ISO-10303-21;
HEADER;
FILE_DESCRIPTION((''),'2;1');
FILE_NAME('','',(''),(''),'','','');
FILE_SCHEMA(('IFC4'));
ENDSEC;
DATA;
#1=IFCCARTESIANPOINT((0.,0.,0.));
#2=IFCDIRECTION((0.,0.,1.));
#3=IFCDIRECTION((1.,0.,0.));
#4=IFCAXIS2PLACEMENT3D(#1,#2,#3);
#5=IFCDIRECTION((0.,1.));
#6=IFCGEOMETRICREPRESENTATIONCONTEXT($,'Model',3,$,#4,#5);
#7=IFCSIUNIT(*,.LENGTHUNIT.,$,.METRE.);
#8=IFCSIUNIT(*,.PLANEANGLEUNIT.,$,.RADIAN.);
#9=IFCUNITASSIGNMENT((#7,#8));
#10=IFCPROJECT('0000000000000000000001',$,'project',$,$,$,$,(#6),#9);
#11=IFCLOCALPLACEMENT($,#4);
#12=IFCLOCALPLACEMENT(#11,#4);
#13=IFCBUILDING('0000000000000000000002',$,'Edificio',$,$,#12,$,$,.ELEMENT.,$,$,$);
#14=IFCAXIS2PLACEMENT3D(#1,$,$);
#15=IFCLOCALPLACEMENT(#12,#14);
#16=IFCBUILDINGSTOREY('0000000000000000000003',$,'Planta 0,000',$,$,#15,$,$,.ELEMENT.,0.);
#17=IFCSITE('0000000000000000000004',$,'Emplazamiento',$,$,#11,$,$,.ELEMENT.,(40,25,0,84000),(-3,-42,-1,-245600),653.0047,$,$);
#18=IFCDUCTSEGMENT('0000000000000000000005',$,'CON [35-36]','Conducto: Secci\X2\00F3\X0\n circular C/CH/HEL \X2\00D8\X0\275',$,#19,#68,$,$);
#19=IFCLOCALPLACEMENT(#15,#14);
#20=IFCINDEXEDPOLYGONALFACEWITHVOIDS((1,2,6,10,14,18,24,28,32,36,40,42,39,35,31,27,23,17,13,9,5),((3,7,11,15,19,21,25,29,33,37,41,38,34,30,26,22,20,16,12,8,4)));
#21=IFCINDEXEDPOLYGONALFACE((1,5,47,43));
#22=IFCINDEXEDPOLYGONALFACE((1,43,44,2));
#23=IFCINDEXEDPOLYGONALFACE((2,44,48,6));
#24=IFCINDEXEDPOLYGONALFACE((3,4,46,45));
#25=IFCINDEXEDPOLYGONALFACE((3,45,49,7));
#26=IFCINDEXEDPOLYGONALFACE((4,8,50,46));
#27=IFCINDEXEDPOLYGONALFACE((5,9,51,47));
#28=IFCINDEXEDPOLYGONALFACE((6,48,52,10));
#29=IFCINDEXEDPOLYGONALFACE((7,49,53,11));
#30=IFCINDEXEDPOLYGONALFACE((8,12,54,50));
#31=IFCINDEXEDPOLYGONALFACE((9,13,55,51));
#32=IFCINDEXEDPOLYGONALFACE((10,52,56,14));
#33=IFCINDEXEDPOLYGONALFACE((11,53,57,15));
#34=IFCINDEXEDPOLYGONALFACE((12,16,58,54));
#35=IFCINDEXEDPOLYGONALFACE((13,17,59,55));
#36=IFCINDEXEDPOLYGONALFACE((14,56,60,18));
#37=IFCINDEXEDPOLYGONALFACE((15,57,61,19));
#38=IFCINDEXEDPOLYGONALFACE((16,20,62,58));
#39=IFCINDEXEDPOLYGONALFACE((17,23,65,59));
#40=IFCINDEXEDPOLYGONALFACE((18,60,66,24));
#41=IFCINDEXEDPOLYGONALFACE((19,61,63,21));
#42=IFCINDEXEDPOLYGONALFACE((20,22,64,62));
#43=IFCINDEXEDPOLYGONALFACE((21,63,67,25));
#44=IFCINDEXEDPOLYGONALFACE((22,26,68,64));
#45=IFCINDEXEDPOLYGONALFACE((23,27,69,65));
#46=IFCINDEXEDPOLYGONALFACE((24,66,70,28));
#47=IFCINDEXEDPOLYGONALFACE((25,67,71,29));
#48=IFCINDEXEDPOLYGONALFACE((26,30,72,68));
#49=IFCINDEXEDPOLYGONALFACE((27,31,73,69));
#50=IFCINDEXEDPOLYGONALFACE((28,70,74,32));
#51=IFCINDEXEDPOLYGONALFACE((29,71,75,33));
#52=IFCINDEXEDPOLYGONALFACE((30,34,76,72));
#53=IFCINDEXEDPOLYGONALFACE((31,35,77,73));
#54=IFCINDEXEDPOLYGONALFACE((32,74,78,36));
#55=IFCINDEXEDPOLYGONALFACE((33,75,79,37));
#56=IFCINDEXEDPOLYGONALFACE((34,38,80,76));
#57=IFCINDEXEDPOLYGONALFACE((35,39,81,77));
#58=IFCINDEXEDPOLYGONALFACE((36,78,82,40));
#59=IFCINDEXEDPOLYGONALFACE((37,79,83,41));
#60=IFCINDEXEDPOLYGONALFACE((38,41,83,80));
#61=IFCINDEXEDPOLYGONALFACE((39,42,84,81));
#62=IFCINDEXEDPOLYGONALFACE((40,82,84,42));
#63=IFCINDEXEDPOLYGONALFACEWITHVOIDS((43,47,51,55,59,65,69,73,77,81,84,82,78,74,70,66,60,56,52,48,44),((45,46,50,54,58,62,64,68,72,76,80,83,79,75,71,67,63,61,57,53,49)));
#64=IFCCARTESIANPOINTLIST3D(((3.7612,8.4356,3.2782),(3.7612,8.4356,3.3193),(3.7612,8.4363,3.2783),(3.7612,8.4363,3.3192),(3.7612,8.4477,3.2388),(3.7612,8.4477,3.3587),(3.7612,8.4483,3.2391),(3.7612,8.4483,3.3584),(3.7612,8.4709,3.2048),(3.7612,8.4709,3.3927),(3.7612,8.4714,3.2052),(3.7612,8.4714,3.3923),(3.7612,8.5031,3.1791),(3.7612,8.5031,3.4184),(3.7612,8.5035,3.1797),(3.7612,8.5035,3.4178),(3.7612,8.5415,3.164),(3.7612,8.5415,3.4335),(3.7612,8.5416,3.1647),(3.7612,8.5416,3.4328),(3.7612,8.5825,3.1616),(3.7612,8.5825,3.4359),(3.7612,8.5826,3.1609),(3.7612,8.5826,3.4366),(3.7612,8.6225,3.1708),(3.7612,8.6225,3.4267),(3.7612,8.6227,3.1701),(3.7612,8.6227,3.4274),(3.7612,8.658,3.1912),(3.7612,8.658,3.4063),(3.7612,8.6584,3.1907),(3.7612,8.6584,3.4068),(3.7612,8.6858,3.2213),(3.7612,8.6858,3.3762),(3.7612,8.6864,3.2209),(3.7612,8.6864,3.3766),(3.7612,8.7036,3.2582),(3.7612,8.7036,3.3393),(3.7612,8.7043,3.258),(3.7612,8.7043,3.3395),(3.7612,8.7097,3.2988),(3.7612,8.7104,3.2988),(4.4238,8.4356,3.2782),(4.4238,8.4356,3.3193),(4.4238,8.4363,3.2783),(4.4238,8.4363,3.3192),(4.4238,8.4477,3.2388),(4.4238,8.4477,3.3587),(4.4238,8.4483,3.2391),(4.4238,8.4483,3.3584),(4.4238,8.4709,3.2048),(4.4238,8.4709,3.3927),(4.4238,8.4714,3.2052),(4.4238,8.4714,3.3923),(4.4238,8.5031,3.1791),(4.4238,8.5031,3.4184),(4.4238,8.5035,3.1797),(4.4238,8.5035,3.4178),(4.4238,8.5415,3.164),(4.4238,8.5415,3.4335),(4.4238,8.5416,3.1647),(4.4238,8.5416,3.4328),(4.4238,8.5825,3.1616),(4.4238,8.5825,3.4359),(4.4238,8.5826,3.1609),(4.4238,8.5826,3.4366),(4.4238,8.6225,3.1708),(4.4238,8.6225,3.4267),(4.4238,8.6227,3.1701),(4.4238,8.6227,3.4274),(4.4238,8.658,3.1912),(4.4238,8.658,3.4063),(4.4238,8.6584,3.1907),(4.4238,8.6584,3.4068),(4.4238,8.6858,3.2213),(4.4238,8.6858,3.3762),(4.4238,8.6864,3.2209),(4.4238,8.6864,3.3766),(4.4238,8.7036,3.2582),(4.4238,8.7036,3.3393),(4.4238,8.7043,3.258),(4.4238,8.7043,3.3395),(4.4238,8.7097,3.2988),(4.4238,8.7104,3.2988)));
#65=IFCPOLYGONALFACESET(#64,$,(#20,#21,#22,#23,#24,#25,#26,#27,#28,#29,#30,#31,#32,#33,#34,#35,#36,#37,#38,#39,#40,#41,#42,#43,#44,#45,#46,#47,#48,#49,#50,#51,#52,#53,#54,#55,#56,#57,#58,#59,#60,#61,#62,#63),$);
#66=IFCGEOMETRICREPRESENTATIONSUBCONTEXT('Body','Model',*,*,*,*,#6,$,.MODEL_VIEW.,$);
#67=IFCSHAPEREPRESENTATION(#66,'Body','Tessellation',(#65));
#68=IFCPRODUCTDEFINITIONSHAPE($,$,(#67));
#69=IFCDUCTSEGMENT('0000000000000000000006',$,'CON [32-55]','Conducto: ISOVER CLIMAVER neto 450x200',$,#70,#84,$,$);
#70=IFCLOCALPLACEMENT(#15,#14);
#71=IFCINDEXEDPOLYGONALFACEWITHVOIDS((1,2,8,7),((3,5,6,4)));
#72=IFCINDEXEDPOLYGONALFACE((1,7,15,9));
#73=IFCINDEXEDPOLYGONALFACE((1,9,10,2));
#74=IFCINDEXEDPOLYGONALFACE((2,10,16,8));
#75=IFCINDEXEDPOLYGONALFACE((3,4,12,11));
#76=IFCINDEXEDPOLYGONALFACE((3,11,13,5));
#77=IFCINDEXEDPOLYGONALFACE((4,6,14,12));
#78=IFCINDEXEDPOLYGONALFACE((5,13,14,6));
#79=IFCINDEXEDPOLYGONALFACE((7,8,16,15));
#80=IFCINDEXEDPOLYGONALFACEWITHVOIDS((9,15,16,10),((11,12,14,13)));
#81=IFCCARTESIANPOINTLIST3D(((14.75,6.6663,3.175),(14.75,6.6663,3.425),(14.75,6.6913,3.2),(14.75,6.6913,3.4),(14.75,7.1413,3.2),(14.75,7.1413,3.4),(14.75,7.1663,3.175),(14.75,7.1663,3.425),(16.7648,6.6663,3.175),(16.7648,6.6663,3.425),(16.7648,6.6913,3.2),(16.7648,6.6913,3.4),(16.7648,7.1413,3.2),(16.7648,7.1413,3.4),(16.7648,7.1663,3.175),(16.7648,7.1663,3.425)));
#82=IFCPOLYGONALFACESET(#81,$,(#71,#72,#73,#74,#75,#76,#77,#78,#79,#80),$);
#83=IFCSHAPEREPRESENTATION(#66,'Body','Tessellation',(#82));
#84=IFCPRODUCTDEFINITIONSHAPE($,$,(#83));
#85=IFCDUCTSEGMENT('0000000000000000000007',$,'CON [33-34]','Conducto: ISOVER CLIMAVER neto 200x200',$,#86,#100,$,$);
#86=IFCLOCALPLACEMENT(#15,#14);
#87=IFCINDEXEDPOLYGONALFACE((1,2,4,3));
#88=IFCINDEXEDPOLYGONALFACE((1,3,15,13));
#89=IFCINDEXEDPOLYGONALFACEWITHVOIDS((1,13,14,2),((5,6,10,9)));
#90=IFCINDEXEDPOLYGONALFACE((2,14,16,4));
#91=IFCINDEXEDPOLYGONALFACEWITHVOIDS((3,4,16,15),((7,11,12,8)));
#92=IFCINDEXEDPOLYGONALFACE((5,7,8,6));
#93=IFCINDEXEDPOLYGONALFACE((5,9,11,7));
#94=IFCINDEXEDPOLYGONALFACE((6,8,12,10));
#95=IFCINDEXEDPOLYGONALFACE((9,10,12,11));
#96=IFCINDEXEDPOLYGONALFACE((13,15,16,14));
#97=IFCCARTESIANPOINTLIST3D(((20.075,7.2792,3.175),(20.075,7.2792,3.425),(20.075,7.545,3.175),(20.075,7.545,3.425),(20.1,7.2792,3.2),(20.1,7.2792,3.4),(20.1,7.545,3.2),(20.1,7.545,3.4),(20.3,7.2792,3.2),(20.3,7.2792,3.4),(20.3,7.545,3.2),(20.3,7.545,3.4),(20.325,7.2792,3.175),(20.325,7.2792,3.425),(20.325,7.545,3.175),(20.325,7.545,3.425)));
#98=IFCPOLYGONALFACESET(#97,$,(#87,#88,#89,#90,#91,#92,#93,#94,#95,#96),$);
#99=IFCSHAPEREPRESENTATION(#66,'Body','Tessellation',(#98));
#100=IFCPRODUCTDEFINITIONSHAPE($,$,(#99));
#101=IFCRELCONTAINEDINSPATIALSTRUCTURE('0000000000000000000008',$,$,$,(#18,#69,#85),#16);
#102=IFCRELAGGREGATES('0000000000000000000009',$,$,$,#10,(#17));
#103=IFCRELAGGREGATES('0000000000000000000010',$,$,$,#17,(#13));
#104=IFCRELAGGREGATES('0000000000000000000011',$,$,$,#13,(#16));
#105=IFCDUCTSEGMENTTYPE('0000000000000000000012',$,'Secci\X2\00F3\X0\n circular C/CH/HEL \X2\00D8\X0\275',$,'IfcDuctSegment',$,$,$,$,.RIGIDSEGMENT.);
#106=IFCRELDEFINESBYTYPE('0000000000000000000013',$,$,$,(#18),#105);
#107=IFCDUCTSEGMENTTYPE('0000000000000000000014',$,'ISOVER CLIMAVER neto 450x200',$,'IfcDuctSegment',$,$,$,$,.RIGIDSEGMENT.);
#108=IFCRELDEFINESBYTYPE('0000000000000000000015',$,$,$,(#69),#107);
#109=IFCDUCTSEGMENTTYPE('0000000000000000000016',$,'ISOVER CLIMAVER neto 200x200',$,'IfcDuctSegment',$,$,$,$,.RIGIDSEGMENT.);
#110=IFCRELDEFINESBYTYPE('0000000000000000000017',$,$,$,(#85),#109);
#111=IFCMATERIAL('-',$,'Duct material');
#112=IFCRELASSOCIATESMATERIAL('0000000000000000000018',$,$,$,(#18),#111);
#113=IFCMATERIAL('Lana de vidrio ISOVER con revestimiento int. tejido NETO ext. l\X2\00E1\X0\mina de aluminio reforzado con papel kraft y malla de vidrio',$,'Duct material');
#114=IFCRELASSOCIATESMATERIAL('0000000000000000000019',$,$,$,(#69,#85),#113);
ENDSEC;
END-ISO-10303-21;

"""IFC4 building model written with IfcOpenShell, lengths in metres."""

from ifc_helpers import new_model, si_unit, direction, frame, origin, origin_with_axes, origin_2d_with_axis, place, context, subcontext, project, spatial, hollow_rectangle, hollow_circle, extrude, material, type_object, element, save


model = new_model("IFC4")

# Units and contexts
model_context = context("Model", 3, world=origin_with_axes(), true_north=direction((0.0, 1.0)))
body_context = subcontext(model_context, "Body", "Model", "MODEL_VIEW")
ifc_project = project(units=[si_unit("LENGTHUNIT", "METRE"), si_unit("PLANEANGLEUNIT", "RADIAN")], contexts=[model_context])

# Site, building, storey
site_placement = place(None, origin_with_axes())
site = spatial("IfcSite", under=ifc_project, at=site_placement, Name="Emplazamiento", CompositionType="ELEMENT", RefLatitude=(40, 25, 0, 84000), RefLongitude=(-3, -42, -1, -245600), RefElevation=653.0047)
building_placement = place(site_placement, origin_with_axes())
building = spatial("IfcBuilding", under=site, at=building_placement, Name="Edificio", CompositionType="ELEMENT")
storey_placement = place(building_placement, origin())
storey = spatial("IfcBuildingStorey", under=building, at=storey_placement, Name="Planta 0,000", CompositionType="ELEMENT", Elevation=0.0)

# Shared definitions
ifc_material_1 = material(Name="Lana de vidrio ISOVER con revestimiento int. tejido NETO ext. lámina de aluminio reforzado con papel kraft y malla de vidrio", Category="Duct material")
ifc_material_2 = material(Name="-", Category="Duct material")

# Duct segments
duct_segment_type_1 = type_object("IfcDuctSegmentType", Name="Sección circular C/CH/HEL Ø275", ApplicableOccurrence="IfcDuctSegment", PredefinedType="RIGIDSEGMENT")
duct_segment_1_placement = place(storey_placement, origin_with_axes())
element("IfcDuctSegment", 1, at=duct_segment_1_placement, inside=storey, type_object=duct_segment_type_1, material=ifc_material_2, Name="CON [35-36]", Description="Conducto: Sección circular C/CH/HEL Ø275", context=body_context, shape_type="SweptSolid", body=[
    extrude(hollow_circle(Radius=0.1382, WallThickness=0.0007, at=origin_2d_with_axis()), frame((3.7612, 8.5722, 3.2988), z_axis=(1.0, 0.0, 0.0), x_axis=(0.0, 1.0, 0.0)), (0.0, 0.0, 1.0), 0.6626),
])
duct_segment_type_2 = type_object("IfcDuctSegmentType", Name="ISOVER CLIMAVER neto 450x200", ApplicableOccurrence="IfcDuctSegment", PredefinedType="RIGIDSEGMENT")
duct_segment_2_placement = place(storey_placement, origin_with_axes())
element("IfcDuctSegment", 2, at=duct_segment_2_placement, inside=storey, type_object=duct_segment_type_2, material=ifc_material_1, Name="CON [32-55]", Description="Conducto: ISOVER CLIMAVER neto 450x200", context=body_context, shape_type="SweptSolid", body=[
    extrude(hollow_rectangle(XDim=0.5, YDim=0.25, WallThickness=0.025, at=origin_2d_with_axis()), frame((16.7648, 6.9163, 3.3), z_axis=(-1.0, 0.0, 0.0), x_axis=(0.0, -1.0, 0.0)), (0.0, 0.0, 1.0), 2.0148),
])
duct_segment_type_3 = type_object("IfcDuctSegmentType", Name="ISOVER CLIMAVER neto 200x200", ApplicableOccurrence="IfcDuctSegment", PredefinedType="RIGIDSEGMENT")
duct_segment_3_placement = place(storey_placement, origin_with_axes())
element("IfcDuctSegment", 3, at=duct_segment_3_placement, inside=storey, type_object=duct_segment_type_3, material=ifc_material_1, Name="CON [33-34]", Description="Conducto: ISOVER CLIMAVER neto 200x200", context=body_context, shape_type="SweptSolid", body=[
    extrude(hollow_rectangle(XDim=0.25, YDim=0.25, WallThickness=0.025, at=origin_2d_with_axis()), frame((20.2, 7.2792, 3.3), z_axis=(0.0, 1.0, 0.0), x_axis=(-1.0, 0.0, 0.0)), (0.0, 0.0, 1.0), 0.2658),
])

save(model, "model.ifc")
